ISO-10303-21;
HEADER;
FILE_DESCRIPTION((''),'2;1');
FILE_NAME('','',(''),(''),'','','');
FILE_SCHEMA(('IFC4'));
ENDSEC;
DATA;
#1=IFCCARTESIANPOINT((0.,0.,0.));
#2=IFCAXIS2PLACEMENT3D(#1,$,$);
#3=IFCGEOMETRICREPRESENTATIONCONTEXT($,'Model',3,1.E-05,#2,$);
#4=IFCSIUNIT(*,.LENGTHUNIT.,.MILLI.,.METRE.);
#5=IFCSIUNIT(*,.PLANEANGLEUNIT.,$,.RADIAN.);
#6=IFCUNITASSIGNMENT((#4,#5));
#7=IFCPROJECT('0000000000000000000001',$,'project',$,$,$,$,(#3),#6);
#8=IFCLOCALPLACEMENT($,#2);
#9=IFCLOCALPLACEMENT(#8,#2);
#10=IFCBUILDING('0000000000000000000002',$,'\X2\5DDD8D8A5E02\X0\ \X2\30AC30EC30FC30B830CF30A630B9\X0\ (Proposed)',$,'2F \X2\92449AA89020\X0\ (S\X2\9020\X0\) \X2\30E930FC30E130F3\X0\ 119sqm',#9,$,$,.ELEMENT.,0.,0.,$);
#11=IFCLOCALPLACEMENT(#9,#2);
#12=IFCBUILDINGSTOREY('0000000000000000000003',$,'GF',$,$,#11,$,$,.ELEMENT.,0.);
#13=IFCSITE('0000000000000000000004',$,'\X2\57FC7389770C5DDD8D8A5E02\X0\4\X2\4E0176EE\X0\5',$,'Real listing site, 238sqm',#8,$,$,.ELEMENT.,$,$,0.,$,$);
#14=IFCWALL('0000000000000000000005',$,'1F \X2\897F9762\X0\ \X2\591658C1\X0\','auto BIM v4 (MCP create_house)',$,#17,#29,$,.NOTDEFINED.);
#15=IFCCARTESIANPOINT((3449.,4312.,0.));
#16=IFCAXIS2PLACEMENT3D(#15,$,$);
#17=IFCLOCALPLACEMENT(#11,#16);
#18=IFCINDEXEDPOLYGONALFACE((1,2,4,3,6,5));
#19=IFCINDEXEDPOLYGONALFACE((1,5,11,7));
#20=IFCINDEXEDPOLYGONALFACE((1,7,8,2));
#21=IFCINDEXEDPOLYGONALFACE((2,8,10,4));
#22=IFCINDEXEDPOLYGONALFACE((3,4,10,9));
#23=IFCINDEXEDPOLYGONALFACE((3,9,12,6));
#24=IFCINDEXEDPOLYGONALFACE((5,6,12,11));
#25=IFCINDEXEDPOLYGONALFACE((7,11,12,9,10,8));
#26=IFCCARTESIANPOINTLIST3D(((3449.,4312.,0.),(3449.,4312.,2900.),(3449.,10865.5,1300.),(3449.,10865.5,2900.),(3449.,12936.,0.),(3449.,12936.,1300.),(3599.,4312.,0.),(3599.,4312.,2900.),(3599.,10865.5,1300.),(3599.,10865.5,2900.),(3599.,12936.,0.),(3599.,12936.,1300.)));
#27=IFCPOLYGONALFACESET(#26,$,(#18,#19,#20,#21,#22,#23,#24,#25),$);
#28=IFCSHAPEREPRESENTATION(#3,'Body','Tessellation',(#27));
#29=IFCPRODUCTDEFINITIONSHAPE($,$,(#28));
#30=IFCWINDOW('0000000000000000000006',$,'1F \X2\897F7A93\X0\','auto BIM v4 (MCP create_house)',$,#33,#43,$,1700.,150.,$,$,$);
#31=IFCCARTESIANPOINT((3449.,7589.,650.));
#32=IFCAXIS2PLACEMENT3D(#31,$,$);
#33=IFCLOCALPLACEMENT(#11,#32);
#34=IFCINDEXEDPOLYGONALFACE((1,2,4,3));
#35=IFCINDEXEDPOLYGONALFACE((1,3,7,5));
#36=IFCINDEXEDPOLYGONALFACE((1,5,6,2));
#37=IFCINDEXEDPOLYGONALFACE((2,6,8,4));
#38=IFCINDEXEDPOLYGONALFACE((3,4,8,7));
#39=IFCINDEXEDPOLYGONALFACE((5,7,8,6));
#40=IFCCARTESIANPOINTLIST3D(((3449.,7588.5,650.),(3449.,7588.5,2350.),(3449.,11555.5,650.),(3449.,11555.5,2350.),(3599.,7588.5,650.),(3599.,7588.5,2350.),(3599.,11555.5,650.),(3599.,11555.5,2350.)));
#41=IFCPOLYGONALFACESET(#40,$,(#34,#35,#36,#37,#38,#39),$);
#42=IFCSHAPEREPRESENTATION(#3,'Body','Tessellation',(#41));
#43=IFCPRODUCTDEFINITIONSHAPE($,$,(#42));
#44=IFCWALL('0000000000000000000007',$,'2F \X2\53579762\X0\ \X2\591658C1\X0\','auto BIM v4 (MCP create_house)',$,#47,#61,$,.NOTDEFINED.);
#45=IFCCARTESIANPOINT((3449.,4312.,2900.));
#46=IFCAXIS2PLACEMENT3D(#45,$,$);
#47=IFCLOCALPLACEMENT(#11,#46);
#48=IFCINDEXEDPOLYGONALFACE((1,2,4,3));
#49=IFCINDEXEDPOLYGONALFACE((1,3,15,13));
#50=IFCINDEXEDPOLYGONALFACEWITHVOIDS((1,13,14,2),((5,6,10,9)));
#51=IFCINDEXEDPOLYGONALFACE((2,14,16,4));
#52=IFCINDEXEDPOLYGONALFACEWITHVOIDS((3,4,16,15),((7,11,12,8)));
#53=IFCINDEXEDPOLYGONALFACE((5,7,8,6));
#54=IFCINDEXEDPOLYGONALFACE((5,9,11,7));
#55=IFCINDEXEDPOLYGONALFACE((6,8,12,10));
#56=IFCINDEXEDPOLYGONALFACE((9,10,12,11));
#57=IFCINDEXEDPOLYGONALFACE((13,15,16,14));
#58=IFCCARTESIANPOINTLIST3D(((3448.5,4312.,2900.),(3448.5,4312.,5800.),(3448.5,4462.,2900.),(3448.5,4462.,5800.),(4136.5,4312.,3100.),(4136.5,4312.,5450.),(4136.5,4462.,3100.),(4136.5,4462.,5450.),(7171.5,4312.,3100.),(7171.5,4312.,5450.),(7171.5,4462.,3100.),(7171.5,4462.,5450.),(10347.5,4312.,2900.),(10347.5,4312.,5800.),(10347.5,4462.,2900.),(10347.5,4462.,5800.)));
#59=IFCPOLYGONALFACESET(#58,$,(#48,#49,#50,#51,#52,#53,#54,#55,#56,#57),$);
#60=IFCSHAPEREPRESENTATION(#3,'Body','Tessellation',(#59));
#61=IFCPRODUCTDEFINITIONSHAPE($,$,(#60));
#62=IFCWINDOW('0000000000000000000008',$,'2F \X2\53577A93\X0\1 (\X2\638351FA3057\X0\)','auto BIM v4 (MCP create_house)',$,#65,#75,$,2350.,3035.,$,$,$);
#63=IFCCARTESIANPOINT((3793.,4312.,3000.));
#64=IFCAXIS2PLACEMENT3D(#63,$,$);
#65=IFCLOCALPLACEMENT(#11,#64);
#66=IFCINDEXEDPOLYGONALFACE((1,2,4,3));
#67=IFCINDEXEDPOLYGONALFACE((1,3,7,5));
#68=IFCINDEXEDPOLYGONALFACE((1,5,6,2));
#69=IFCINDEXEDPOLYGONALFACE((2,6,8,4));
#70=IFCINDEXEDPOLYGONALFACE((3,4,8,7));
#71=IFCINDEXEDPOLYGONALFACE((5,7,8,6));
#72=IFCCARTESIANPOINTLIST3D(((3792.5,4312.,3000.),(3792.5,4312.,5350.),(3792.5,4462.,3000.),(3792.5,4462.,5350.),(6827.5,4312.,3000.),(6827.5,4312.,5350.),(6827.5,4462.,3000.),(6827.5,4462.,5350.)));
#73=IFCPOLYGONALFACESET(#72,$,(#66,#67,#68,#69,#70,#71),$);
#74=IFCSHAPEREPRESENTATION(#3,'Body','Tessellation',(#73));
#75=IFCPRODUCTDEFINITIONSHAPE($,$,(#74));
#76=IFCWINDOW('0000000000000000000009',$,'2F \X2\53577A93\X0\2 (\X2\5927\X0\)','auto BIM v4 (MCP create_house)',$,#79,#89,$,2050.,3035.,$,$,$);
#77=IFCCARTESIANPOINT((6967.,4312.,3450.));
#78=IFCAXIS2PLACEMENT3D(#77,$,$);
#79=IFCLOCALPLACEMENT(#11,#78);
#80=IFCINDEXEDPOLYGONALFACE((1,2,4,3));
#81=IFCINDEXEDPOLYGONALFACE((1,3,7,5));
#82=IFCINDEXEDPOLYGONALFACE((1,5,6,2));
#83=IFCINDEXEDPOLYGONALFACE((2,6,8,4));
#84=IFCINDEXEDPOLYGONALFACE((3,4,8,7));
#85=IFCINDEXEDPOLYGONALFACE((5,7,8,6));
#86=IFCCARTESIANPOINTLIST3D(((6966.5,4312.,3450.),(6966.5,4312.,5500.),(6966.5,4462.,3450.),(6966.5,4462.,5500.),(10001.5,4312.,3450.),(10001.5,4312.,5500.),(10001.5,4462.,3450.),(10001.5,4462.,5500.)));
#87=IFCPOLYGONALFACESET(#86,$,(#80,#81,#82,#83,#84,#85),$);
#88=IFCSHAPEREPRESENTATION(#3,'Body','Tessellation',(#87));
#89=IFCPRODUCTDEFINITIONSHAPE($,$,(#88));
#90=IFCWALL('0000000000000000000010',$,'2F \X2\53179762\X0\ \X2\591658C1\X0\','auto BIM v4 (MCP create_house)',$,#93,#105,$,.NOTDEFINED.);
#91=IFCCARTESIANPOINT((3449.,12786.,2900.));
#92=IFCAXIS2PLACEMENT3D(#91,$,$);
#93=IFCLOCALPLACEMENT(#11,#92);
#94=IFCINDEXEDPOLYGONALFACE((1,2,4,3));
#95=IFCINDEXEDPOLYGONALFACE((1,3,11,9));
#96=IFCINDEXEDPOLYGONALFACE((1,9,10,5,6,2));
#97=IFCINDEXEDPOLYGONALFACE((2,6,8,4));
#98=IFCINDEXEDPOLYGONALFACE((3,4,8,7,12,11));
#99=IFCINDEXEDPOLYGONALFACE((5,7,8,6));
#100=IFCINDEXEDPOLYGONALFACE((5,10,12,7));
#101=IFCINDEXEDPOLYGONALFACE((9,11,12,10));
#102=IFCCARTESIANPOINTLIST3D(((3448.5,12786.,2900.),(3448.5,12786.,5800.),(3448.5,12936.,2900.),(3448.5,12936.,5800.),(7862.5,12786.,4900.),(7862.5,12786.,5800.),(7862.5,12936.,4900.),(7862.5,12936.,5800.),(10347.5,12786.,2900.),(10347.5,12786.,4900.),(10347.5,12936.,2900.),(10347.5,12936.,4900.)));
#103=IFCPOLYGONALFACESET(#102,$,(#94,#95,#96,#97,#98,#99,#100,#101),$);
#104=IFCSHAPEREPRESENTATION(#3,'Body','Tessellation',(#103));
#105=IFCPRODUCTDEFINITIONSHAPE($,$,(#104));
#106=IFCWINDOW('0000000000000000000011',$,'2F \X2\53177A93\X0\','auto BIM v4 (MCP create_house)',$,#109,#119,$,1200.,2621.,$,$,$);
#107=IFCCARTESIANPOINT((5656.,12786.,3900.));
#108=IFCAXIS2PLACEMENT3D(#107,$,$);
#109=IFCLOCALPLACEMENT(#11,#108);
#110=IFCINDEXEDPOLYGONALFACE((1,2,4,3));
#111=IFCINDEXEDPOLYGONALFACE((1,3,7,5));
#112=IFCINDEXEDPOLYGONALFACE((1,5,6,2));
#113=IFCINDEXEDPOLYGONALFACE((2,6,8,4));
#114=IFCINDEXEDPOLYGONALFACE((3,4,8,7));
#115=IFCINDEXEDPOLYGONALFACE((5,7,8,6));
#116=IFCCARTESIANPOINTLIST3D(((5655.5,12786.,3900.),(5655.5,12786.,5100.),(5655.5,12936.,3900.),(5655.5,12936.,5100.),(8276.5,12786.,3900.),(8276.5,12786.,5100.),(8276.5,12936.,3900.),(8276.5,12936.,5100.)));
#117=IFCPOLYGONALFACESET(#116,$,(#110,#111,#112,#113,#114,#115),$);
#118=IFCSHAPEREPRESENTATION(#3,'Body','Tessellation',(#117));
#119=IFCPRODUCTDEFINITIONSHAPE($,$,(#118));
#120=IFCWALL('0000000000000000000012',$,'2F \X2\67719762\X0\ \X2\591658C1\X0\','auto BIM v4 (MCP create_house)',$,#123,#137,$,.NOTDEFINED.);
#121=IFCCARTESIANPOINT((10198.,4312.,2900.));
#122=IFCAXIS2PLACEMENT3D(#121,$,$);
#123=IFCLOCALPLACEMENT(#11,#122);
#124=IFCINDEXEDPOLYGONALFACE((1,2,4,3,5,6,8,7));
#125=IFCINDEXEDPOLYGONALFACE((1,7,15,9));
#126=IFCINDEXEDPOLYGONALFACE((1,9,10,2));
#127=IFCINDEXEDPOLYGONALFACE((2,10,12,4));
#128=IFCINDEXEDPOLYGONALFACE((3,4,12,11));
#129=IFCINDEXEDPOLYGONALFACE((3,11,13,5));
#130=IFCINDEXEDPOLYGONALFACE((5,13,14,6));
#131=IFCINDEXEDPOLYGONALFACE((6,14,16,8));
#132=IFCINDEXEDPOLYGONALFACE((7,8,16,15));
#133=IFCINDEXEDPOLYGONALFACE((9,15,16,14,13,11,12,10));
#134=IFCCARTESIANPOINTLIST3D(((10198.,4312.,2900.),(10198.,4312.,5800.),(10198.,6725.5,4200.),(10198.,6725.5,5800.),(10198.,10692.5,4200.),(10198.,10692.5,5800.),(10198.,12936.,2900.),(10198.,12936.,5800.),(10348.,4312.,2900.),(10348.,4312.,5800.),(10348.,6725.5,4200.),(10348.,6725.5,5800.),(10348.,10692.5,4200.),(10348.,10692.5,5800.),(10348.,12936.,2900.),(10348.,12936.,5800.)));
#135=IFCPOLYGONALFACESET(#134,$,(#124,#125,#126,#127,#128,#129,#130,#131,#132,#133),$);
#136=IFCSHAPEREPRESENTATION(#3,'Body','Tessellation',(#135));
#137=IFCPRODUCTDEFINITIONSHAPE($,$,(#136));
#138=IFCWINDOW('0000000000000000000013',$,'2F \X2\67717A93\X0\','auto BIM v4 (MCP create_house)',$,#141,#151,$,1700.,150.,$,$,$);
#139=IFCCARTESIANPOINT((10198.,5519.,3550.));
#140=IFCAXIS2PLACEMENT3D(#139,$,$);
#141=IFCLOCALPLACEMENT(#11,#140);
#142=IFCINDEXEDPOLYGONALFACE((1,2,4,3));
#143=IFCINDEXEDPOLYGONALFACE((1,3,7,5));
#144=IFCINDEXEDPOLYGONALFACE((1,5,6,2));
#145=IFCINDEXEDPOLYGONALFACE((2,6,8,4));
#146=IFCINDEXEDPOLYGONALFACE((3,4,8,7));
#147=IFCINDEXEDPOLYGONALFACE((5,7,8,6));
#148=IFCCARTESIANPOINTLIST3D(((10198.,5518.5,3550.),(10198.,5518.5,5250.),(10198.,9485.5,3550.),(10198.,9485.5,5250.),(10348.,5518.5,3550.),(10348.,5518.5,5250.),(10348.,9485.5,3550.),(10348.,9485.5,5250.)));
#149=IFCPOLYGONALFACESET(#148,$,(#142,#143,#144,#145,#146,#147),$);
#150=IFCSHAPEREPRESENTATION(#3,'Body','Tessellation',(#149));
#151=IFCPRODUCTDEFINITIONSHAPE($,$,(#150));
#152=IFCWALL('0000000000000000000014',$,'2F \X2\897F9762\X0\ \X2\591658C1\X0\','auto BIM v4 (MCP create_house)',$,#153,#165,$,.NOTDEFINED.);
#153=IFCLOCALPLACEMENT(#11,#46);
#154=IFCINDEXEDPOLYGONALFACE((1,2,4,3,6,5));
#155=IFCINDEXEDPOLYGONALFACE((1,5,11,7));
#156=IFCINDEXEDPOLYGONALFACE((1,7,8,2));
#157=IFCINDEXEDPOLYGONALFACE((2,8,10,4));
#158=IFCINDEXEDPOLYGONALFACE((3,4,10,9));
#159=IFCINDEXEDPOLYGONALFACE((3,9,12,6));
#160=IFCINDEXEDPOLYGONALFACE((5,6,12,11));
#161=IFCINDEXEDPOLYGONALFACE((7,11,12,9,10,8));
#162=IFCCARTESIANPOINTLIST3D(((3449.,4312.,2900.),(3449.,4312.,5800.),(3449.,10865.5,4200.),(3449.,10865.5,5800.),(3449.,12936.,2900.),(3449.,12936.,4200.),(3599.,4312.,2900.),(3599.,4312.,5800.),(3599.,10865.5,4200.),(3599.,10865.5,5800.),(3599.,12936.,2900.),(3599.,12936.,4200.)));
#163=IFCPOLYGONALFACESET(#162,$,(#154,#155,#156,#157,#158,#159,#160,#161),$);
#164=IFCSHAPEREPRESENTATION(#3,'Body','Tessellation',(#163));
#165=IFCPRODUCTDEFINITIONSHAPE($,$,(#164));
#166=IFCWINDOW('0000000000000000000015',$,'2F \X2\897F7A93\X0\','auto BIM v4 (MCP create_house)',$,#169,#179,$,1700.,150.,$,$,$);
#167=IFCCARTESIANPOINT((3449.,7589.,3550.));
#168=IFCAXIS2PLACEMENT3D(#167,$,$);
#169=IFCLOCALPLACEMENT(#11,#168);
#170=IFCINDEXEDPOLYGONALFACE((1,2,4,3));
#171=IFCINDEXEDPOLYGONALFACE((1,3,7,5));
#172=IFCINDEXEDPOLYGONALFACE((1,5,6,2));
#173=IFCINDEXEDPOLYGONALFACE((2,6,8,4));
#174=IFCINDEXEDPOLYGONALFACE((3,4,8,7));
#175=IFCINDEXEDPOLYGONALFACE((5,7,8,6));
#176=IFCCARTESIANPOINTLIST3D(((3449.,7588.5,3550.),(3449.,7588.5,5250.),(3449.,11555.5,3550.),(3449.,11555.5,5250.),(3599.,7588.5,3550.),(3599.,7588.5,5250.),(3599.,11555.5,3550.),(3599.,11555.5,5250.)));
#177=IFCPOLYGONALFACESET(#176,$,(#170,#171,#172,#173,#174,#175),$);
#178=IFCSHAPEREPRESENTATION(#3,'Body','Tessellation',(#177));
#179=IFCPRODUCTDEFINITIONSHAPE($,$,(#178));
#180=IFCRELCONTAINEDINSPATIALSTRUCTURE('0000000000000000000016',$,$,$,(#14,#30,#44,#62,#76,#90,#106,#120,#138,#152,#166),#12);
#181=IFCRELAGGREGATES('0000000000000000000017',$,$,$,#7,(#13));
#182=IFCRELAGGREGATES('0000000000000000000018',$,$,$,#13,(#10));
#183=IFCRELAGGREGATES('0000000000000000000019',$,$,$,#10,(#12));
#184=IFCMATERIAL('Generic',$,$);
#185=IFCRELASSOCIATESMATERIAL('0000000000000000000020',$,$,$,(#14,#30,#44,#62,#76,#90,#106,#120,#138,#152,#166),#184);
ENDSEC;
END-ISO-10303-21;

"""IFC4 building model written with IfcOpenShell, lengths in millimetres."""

from ifc_helpers import new_model, si_unit, frame, frame_2d, origin, place, context, project, spatial, rectangle, extrude, material, element, fill, save


model = new_model("IFC4")

# Units and contexts
model_context = context("Model", 3, precision=1e-05, world=origin())
ifc_project = project(units=[si_unit("LENGTHUNIT", "METRE", prefix="MILLI"), si_unit("PLANEANGLEUNIT", "RADIAN")], contexts=[model_context])

# Site, building, storey
site_placement = place(None, origin())
site = spatial("IfcSite", under=ifc_project, at=site_placement, Name="埼玉県川越市4丁目5", ObjectType="Real listing site, 238sqm", CompositionType="ELEMENT", RefElevation=0.0)
building_placement = place(site_placement, origin())
building = spatial("IfcBuilding", under=site, at=building_placement, Name="川越市 ガレージハウス (Proposed)", ObjectType="2F 鉄骨造 (S造) ラーメン 119sqm", CompositionType="ELEMENT", ElevationOfRefHeight=0.0, ElevationOfTerrain=0.0)
storey_placement = place(building_placement, origin())
storey = spatial("IfcBuildingStorey", under=building, at=storey_placement, Name="GF", CompositionType="ELEMENT", Elevation=0.0)

# Shared definitions
ifc_material = material(Name="Generic")

# Wall, opening, window
wall_1_placement = place(storey_placement, frame((3449.0, 4312.0, 0.0)))
wall_1 = element("IfcWall", 1, at=wall_1_placement, inside=storey, material=ifc_material, Name="1F 西面 外壁", Description="auto BIM v4 (MCP create_house)", PredefinedType="NOTDEFINED", context=model_context, shape_type="SweptSolid", body=[
    extrude(rectangle(XDim=150.0, YDim=8624.0, at=frame_2d((75.0, 4312.0))), frame((3449.0, 4312.0, 0.0)), (0.0, 0.0, 1.0), 2900.0),
])
opening_1_placement = place(storey_placement, frame((3449.0, 7589.0, 650.0)))
opening_1 = element("IfcOpeningElement", 2, at=opening_1_placement, cuts=wall_1, PredefinedType="NOTDEFINED", context=model_context, shape_type="SweptSolid", body=[
    extrude(rectangle(XDim=150.0, YDim=3967.0, at=frame_2d((75.0, 1983.0))), frame((3449.0, 7589.0, 650.0)), (0.0, 0.0, 1.0), 1700.0),
])
window_1_placement = place(storey_placement, frame((3449.0, 7589.0, 650.0)))
window_1 = element("IfcWindow", 3, at=window_1_placement, inside=storey, material=ifc_material, Name="1F 西窓", Description="auto BIM v4 (MCP create_house)", OverallHeight=1700.0, OverallWidth=150.0, context=model_context, shape_type="SweptSolid", body=[
    extrude(rectangle(XDim=150.0, YDim=3967.0, at=frame_2d((75.0, 1983.0))), frame((3449.0, 7589.0, 650.0)), (0.0, 0.0, 1.0), 1700.0),
])
fill(opening_1, window_1)

# Wall, openings, windows
wall_2_placement = place(storey_placement, frame((3449.0, 4312.0, 2900.0)))
wall_2 = element("IfcWall", 4, at=wall_2_placement, inside=storey, material=ifc_material, Name="2F 南面 外壁", Description="auto BIM v4 (MCP create_house)", PredefinedType="NOTDEFINED", context=model_context, shape_type="SweptSolid", body=[
    extrude(rectangle(XDim=6899.0, YDim=150.0, at=frame_2d((3449.0, 75.0))), frame((3449.0, 4312.0, 2900.0)), (0.0, 0.0, 1.0), 2900.0),
])
opening_2_placement = place(storey_placement, frame((3793.0, 4312.0, 3000.0)))
opening_2 = element("IfcOpeningElement", 5, at=opening_2_placement, cuts=wall_2, PredefinedType="NOTDEFINED", context=model_context, shape_type="SweptSolid", body=[
    extrude(rectangle(XDim=3035.0, YDim=150.0, at=frame_2d((1517.0, 75.0))), frame((3793.0, 4312.0, 3000.0)), (0.0, 0.0, 1.0), 2350.0),
])
opening_3_placement = place(storey_placement, frame((6967.0, 4312.0, 3450.0)))
opening_3 = element("IfcOpeningElement", 6, at=opening_3_placement, cuts=wall_2, PredefinedType="NOTDEFINED", context=model_context, shape_type="SweptSolid", body=[
    extrude(rectangle(XDim=3035.0, YDim=150.0, at=frame_2d((1517.0, 75.0))), frame((6967.0, 4312.0, 3450.0)), (0.0, 0.0, 1.0), 2050.0),
])
window_2_placement = place(storey_placement, frame((3793.0, 4312.0, 3000.0)))
window_2 = element("IfcWindow", 7, at=window_2_placement, inside=storey, material=ifc_material, Name="2F 南窓1 (掃出し)", Description="auto BIM v4 (MCP create_house)", OverallHeight=2350.0, OverallWidth=3035.0, context=model_context, shape_type="SweptSolid", body=[
    extrude(rectangle(XDim=3035.0, YDim=150.0, at=frame_2d((1517.0, 75.0))), frame((3793.0, 4312.0, 3000.0)), (0.0, 0.0, 1.0), 2350.0),
])
fill(opening_2, window_2)
window_3_placement = place(storey_placement, frame((6967.0, 4312.0, 3450.0)))
window_3 = element("IfcWindow", 8, at=window_3_placement, inside=storey, material=ifc_material, Name="2F 南窓2 (大)", Description="auto BIM v4 (MCP create_house)", OverallHeight=2050.0, OverallWidth=3035.0, context=model_context, shape_type="SweptSolid", body=[
    extrude(rectangle(XDim=3035.0, YDim=150.0, at=frame_2d((1517.0, 75.0))), frame((6967.0, 4312.0, 3450.0)), (0.0, 0.0, 1.0), 2050.0),
])
fill(opening_3, window_3)

# Walls, openings, windows
wall_3_placement = place(storey_placement, frame((3449.0, 12786.0, 2900.0)))
wall_3 = element("IfcWall", 9, at=wall_3_placement, inside=storey, material=ifc_material, Name="2F 北面 外壁", Description="auto BIM v4 (MCP create_house)", PredefinedType="NOTDEFINED", context=model_context, shape_type="SweptSolid", body=[
    extrude(rectangle(XDim=6899.0, YDim=150.0, at=frame_2d((3449.0, 75.0))), frame((3449.0, 12786.0, 2900.0)), (0.0, 0.0, 1.0), 2900.0),
])
opening_4_placement = place(storey_placement, frame((5656.0, 12786.0, 3900.0)))
opening_4 = element("IfcOpeningElement", 10, at=opening_4_placement, cuts=wall_3, PredefinedType="NOTDEFINED", context=model_context, shape_type="SweptSolid", body=[
    extrude(rectangle(XDim=2621.0, YDim=150.0, at=frame_2d((1310.0, 75.0))), frame((5656.0, 12786.0, 3900.0)), (0.0, 0.0, 1.0), 1200.0),
])
window_4_placement = place(storey_placement, frame((5656.0, 12786.0, 3900.0)))
window_4 = element("IfcWindow", 11, at=window_4_placement, inside=storey, material=ifc_material, Name="2F 北窓", Description="auto BIM v4 (MCP create_house)", OverallHeight=1200.0, OverallWidth=2621.0, context=model_context, shape_type="SweptSolid", body=[
    extrude(rectangle(XDim=2621.0, YDim=150.0, at=frame_2d((1310.0, 75.0))), frame((5656.0, 12786.0, 3900.0)), (0.0, 0.0, 1.0), 1200.0),
])
fill(opening_4, window_4)
wall_4_placement = place(storey_placement, frame((10198.0, 4312.0, 2900.0)))
wall_4 = element("IfcWall", 12, at=wall_4_placement, inside=storey, material=ifc_material, Name="2F 東面 外壁", Description="auto BIM v4 (MCP create_house)", PredefinedType="NOTDEFINED", context=model_context, shape_type="SweptSolid", body=[
    extrude(rectangle(XDim=150.0, YDim=8624.0, at=frame_2d((75.0, 4312.0))), frame((10198.0, 4312.0, 2900.0)), (0.0, 0.0, 1.0), 2900.0),
])
opening_5_placement = place(storey_placement, frame((10198.0, 5519.0, 3550.0)))
opening_5 = element("IfcOpeningElement", 13, at=opening_5_placement, cuts=wall_4, PredefinedType="NOTDEFINED", context=model_context, shape_type="SweptSolid", body=[
    extrude(rectangle(XDim=150.0, YDim=3967.0, at=frame_2d((75.0, 1983.0))), frame((10198.0, 5519.0, 3550.0)), (0.0, 0.0, 1.0), 1700.0),
])
window_5_placement = place(storey_placement, frame((10198.0, 5519.0, 3550.0)))
window_5 = element("IfcWindow", 14, at=window_5_placement, inside=storey, material=ifc_material, Name="2F 東窓", Description="auto BIM v4 (MCP create_house)", OverallHeight=1700.0, OverallWidth=150.0, context=model_context, shape_type="SweptSolid", body=[
    extrude(rectangle(XDim=150.0, YDim=3967.0, at=frame_2d((75.0, 1983.0))), frame((10198.0, 5519.0, 3550.0)), (0.0, 0.0, 1.0), 1700.0),
])
fill(opening_5, window_5)
wall_5_placement = place(storey_placement, frame((3449.0, 4312.0, 2900.0)))
wall_5 = element("IfcWall", 15, at=wall_5_placement, inside=storey, material=ifc_material, Name="2F 西面 外壁", Description="auto BIM v4 (MCP create_house)", PredefinedType="NOTDEFINED", context=model_context, shape_type="SweptSolid", body=[
    extrude(rectangle(XDim=150.0, YDim=8624.0, at=frame_2d((75.0, 4312.0))), frame((3449.0, 4312.0, 2900.0)), (0.0, 0.0, 1.0), 2900.0),
])
opening_6_placement = place(storey_placement, frame((3449.0, 7589.0, 3550.0)))
opening_6 = element("IfcOpeningElement", 16, at=opening_6_placement, cuts=wall_5, PredefinedType="NOTDEFINED", context=model_context, shape_type="SweptSolid", body=[
    extrude(rectangle(XDim=150.0, YDim=3967.0, at=frame_2d((75.0, 1983.0))), frame((3449.0, 7589.0, 3550.0)), (0.0, 0.0, 1.0), 1700.0),
])
window_6_placement = place(storey_placement, frame((3449.0, 7589.0, 3550.0)))
window_6 = element("IfcWindow", 17, at=window_6_placement, inside=storey, material=ifc_material, Name="2F 西窓", Description="auto BIM v4 (MCP create_house)", OverallHeight=1700.0, OverallWidth=150.0, context=model_context, shape_type="SweptSolid", body=[
    extrude(rectangle(XDim=150.0, YDim=3967.0, at=frame_2d((75.0, 1983.0))), frame((3449.0, 7589.0, 3550.0)), (0.0, 0.0, 1.0), 1700.0),
])
fill(opening_6, window_6)

save(model, "model.ifc")
